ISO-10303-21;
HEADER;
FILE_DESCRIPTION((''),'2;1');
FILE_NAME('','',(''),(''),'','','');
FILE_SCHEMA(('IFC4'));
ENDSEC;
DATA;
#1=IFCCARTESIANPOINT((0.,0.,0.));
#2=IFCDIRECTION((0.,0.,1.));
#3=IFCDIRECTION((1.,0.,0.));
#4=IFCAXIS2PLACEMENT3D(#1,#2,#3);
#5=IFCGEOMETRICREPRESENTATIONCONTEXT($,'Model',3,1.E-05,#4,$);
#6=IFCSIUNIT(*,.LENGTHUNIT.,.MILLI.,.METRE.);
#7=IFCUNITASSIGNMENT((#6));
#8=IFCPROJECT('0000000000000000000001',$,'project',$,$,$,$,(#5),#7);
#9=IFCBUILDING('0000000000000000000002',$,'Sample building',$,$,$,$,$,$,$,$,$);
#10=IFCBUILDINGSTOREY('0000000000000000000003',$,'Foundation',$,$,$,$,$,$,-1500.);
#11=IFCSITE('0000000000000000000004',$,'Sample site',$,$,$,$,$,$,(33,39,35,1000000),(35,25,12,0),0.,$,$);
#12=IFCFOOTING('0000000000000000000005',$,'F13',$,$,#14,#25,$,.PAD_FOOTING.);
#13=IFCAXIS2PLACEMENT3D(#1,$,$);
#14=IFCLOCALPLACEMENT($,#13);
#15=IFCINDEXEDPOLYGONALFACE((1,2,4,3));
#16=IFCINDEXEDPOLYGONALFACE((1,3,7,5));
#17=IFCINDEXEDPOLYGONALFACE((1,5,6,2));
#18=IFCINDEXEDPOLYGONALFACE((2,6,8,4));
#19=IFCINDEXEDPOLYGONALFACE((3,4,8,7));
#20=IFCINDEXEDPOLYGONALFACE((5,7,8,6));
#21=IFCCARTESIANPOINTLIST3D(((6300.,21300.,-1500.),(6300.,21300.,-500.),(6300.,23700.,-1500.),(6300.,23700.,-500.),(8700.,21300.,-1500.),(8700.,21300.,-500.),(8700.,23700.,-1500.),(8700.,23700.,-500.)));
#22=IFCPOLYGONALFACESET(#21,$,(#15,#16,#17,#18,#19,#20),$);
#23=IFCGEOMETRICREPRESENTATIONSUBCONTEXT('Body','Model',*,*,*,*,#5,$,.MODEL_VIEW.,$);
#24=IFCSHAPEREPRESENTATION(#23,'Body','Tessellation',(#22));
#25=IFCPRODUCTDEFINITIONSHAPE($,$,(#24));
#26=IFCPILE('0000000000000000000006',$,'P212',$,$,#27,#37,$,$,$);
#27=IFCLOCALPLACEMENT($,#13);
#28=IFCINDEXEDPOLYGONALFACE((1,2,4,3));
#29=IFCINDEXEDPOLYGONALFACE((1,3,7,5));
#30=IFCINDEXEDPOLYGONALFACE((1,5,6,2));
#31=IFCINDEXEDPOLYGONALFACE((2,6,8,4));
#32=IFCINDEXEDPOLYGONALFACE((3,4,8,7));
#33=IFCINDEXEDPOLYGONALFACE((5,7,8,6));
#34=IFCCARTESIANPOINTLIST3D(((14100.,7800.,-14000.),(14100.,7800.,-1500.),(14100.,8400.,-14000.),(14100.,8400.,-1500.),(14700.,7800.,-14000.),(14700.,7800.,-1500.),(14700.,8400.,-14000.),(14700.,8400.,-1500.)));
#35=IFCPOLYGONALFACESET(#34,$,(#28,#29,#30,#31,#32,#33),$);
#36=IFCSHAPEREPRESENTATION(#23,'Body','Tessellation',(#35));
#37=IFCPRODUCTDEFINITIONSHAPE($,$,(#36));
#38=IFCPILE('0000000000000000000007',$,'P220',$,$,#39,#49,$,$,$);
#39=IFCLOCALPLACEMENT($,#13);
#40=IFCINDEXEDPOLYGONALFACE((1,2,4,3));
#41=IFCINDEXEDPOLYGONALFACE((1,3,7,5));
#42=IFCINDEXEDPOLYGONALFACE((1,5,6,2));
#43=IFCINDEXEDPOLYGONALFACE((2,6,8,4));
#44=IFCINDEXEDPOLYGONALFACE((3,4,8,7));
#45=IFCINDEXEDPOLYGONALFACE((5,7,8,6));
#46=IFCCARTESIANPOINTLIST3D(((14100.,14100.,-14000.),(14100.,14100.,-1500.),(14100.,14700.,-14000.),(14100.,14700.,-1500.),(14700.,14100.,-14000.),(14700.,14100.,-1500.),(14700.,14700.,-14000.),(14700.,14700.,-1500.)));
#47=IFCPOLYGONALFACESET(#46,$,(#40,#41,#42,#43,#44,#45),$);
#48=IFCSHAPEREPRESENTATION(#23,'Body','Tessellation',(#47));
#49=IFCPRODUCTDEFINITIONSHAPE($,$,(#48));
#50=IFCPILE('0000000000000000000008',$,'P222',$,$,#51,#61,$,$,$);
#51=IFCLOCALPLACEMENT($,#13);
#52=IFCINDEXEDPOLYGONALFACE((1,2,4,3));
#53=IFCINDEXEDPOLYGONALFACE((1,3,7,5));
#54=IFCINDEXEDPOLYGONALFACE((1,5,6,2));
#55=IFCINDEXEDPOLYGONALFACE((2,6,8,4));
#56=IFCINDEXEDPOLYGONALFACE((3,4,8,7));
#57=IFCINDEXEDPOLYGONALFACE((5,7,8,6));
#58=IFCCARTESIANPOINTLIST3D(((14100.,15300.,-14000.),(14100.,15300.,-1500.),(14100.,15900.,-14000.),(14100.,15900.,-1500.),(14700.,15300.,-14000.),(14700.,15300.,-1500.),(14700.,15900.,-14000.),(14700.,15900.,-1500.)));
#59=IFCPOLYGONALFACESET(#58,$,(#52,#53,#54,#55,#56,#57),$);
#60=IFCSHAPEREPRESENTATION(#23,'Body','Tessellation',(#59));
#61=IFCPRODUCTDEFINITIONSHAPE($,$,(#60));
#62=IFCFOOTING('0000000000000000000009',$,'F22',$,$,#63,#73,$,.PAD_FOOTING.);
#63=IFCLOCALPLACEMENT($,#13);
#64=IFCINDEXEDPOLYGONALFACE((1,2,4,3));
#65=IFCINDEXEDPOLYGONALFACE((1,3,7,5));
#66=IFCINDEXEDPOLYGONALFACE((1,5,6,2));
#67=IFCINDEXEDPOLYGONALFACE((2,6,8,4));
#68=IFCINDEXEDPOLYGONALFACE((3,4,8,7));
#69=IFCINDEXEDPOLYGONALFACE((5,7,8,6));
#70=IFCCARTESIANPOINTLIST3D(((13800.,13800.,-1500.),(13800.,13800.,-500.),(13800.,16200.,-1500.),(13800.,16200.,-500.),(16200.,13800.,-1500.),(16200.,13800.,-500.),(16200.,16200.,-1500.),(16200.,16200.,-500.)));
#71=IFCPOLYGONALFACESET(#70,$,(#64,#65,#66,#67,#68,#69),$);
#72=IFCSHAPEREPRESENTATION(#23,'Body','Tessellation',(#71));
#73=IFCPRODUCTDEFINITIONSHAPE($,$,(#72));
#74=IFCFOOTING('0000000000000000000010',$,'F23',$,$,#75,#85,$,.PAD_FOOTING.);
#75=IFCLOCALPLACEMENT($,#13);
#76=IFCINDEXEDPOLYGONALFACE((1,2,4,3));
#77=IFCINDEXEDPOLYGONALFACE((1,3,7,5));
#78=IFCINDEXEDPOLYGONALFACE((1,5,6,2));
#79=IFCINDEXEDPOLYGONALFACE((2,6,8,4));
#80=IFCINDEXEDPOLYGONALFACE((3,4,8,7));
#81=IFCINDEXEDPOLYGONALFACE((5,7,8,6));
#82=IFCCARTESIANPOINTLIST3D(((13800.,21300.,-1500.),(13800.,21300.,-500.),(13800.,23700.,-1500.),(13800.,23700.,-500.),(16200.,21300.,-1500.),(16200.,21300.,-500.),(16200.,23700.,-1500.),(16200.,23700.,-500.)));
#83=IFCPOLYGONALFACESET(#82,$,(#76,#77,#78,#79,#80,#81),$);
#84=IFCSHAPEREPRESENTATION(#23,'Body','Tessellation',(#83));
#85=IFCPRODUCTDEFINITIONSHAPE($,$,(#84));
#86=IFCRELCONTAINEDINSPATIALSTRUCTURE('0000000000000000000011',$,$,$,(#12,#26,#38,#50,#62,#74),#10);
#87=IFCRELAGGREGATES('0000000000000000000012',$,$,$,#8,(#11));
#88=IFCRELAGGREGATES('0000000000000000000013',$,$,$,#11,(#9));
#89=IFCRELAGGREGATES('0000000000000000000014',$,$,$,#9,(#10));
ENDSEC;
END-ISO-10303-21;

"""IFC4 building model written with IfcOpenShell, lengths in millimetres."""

from ifc_helpers import new_model, si_unit, frame, origin_with_axes, place, context, subcontext, project, spatial, indexed_curve, outline, extrude, element, save


model = new_model("IFC4")

# Units and contexts
model_context = context("Model", 3, precision=1e-05, world=origin_with_axes())
body_context = subcontext(model_context, "Body", "Model", "MODEL_VIEW")
ifc_project = project(units=[si_unit("LENGTHUNIT", "METRE", prefix="MILLI")], contexts=[model_context])

# Site, building, storey
site = spatial("IfcSite", under=ifc_project, Name="Sample site", RefLatitude=(33, 39, 35, 1000000), RefLongitude=(35, 25, 12, 0), RefElevation=0.0)
building = spatial("IfcBuilding", under=site, Name="Sample building")
storey = spatial("IfcBuildingStorey", under=building, Name="Foundation", Elevation=-1500.0)

# Footing
footing_1_placement = place(None, frame((6300.0, 21300.0, -1500.0), z_axis=(0.0, 0.0, 1.0), x_axis=(1.0, 0.0, 0.0)))
element("IfcFooting", 1, at=footing_1_placement, inside=storey, Name="F13", PredefinedType="PAD_FOOTING", context=body_context, shape_type="SweptSolid", body=[
    extrude(outline(indexed_curve([(0.0, 0.0), (0.0, 2400.0), (2400.0, 2400.0), (2400.0, 0.0), (0.0, 0.0)], self_intersect=False)), origin_with_axes(), (0.0, 0.0, 1.0), 1000.0),
])

# Piles
for number, where, z_axis, x_axis, name in (
    (2, (14100.0, 7800.0, -14000.0), (0.0, 0.0, 1.0), (1.0, 0.0, 0.0), "P212"),
    (3, (14100.0, 14100.0, -14000.0), (0.0, 0.0, 1.0), (1.0, 0.0, 0.0), "P220"),
    (4, (14100.0, 15300.0, -14000.0), (0.0, 0.0, 1.0), (1.0, 0.0, 0.0), "P222"),
):
    element("IfcPile", number, at=place(None, frame(where, z_axis=z_axis, x_axis=x_axis)), inside=storey, Name=name, context=body_context, shape_type="SweptSolid", body=[
        extrude(outline(indexed_curve([(0.0, 0.0), (0.0, 600.0), (600.0, 600.0), (600.0, 0.0), (0.0, 0.0)], self_intersect=False)), origin_with_axes(), (0.0, 0.0, 1.0), 12500.0),
    ])

# Footings
for number, where, z_axis, x_axis, name in (
    (5, (13800.0, 13800.0, -1500.0), (0.0, 0.0, 1.0), (1.0, 0.0, 0.0), "F22"),
    (6, (13800.0, 21300.0, -1500.0), (0.0, 0.0, 1.0), (1.0, 0.0, 0.0), "F23"),
):
    element("IfcFooting", number, at=place(None, frame(where, z_axis=z_axis, x_axis=x_axis)), inside=storey, Name=name, PredefinedType="PAD_FOOTING", context=body_context, shape_type="SweptSolid", body=[
        extrude(outline(indexed_curve([(0.0, 0.0), (0.0, 2400.0), (2400.0, 2400.0), (2400.0, 0.0), (0.0, 0.0)], self_intersect=False)), origin_with_axes(), (0.0, 0.0, 1.0), 1000.0),
    ])

save(model, "model.ifc")
